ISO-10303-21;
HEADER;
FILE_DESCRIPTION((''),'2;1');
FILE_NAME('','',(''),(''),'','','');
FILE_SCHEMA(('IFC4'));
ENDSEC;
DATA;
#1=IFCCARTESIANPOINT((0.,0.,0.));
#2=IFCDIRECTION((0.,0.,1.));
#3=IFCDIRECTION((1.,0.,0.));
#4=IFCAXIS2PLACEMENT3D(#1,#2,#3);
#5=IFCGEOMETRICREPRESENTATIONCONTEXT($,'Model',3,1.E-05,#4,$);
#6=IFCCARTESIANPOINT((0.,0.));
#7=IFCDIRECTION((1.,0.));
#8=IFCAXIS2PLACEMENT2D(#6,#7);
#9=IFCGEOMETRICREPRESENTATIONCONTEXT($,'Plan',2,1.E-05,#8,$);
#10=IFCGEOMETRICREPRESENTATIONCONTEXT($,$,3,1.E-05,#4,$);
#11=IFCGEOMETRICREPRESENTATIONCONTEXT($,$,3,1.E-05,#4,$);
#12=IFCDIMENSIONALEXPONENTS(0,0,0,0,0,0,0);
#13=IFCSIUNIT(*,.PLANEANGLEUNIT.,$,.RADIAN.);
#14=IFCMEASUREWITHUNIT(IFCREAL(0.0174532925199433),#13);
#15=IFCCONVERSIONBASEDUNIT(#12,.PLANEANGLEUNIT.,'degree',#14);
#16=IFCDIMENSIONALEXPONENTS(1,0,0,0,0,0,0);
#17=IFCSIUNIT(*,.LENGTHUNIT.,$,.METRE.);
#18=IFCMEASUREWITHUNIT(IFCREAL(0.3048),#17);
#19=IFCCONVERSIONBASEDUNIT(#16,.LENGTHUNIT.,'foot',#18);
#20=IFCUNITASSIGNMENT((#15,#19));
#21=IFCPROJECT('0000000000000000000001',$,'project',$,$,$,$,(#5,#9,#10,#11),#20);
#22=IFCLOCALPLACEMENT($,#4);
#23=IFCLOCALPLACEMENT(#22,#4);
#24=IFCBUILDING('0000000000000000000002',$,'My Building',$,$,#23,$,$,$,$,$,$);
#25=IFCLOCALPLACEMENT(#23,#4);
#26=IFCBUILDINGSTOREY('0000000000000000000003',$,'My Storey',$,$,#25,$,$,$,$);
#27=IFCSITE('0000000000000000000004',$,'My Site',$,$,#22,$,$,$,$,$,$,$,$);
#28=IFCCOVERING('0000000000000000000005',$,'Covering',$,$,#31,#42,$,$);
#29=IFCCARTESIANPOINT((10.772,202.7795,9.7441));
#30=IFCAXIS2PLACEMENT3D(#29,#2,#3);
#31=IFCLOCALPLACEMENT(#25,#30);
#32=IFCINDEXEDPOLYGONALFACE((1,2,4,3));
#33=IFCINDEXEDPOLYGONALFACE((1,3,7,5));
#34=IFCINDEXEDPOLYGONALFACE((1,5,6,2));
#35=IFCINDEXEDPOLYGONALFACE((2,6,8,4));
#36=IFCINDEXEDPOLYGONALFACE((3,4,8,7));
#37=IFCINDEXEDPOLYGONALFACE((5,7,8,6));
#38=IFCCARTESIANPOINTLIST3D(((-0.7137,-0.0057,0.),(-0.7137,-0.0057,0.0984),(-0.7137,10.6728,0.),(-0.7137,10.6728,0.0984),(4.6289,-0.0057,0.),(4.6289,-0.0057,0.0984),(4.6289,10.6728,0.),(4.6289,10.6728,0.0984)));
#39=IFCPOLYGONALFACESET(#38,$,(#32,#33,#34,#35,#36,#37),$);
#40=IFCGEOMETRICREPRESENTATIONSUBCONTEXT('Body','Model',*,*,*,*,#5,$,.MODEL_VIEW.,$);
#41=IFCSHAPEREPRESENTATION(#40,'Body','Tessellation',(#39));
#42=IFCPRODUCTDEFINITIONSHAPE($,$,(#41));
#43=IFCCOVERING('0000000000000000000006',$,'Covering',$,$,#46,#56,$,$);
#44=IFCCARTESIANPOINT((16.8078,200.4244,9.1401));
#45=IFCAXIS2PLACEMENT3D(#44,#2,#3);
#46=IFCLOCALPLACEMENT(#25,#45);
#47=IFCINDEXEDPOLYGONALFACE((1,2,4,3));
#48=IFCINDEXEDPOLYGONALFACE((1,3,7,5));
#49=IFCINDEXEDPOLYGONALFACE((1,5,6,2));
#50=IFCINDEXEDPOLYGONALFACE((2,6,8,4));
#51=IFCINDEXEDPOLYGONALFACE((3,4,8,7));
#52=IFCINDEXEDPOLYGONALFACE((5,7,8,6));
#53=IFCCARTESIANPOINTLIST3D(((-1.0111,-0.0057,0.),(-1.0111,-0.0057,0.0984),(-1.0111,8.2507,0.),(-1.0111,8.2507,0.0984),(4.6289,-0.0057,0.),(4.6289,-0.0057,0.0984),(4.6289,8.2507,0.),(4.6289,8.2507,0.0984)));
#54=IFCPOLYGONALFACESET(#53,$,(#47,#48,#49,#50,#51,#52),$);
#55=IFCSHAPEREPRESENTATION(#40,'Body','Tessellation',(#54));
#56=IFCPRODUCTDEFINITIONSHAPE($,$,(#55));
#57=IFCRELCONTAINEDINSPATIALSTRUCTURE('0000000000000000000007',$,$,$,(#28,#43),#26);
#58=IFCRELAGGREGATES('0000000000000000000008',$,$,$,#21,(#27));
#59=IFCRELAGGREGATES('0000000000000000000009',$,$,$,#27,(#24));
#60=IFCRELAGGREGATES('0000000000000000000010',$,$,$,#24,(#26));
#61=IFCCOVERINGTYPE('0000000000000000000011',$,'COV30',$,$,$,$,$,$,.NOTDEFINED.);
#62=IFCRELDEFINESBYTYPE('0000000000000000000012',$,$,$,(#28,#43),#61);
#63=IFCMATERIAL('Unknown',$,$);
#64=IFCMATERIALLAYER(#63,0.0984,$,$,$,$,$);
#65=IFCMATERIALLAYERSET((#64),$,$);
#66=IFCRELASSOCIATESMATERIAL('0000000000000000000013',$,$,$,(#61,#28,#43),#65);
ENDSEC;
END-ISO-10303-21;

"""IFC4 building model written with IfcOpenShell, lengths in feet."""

from ifc_helpers import new_model, entity, si_unit, converted_unit, frame, origin_with_axes, origin_2d_with_axis, place, context, subcontext, project, spatial, line, indexed_curve, outline, extrude, material, layer, layer_set, layer_usage, type_object, element, save


model = new_model("IFC4")

# Units and contexts
model_context = context("Model", 3, precision=1e-05, world=origin_with_axes())
plan_context = context("Plan", 2, precision=1e-05, world=origin_2d_with_axis())
context_of_model_1 = context(None, 3, precision=1e-05, world=origin_with_axes())
context_of_model_2 = context(None, 3, precision=1e-05, world=origin_with_axes())
body_context = subcontext(model_context, "Body", "Model", "MODEL_VIEW")
ifc_project = project(units=[converted_unit("PLANEANGLEUNIT", "degree", entity("IfcReal", 0.0174532925199433), si_unit("PLANEANGLEUNIT", "RADIAN"), dimensions=[0, 0, 0, 0, 0, 0, 0]), converted_unit("LENGTHUNIT", "foot", entity("IfcReal", 0.3048), si_unit("LENGTHUNIT", "METRE"), dimensions=[1, 0, 0, 0, 0, 0, 0])], contexts=[model_context, plan_context, context_of_model_1, context_of_model_2])

# Site, building, storey
site_placement = place(None, origin_with_axes())
site = spatial("IfcSite", under=ifc_project, at=site_placement, Name="My Site")
building_placement = place(site_placement, origin_with_axes())
building = spatial("IfcBuilding", under=site, at=building_placement, Name="My Building")
storey_placement = place(building_placement, origin_with_axes())
storey = spatial("IfcBuildingStorey", under=building, at=storey_placement, Name="My Storey")

# Coverings
ifc_material_1 = material(Name="Unknown")
ifc_layer_1 = layer(ifc_material_1, 0.0984)
ifc_layer_set_1 = layer_set([ifc_layer_1])
ifc_layer_usage_1 = layer_usage(ifc_layer_set_1, "AXIS3", "POSITIVE", 0.0)
covering_type = type_object("IfcCoveringType", Name="COV30", PredefinedType="NOTDEFINED", material=ifc_layer_set_1)
covering_1_placement = place(storey_placement, frame((10.772, 202.7795, 9.7441), z_axis=(0.0, 0.0, 1.0), x_axis=(1.0, 0.0, 0.0)))
element("IfcCovering", 1, at=covering_1_placement, inside=storey, type_object=covering_type, material=ifc_layer_usage_1, Name="Covering", context=body_context, shape_type="SweptSolid", body=[
    extrude(outline(indexed_curve([(4.6289, -0.0057), (4.6289, 10.6728), (-0.7137, 10.6728), (-0.7137, -0.0057)], segments=[line(3, 2), line(2, 1), line(1, 4), line(4, 3)], self_intersect=False)), None, (0.0, 0.0, 1.0), 0.0984),
])
ifc_layer_usage_2 = layer_usage(ifc_layer_set_1, "AXIS3", "POSITIVE", 0.0)
covering_2_placement = place(storey_placement, frame((16.8078, 200.4244, 9.1401), z_axis=(0.0, 0.0, 1.0), x_axis=(1.0, 0.0, 0.0)))
element("IfcCovering", 2, at=covering_2_placement, inside=storey, type_object=covering_type, material=ifc_layer_usage_2, Name="Covering", context=body_context, shape_type="SweptSolid", body=[
    extrude(outline(indexed_curve([(-1.0111, 8.2507), (4.6289, 8.2507), (4.6289, -0.0057), (-1.0111, -0.0057)], segments=[line(3, 2), line(2, 1), line(1, 4), line(4, 3)], self_intersect=False)), None, (0.0, 0.0, 1.0), 0.0984),
])

save(model, "model.ifc")
